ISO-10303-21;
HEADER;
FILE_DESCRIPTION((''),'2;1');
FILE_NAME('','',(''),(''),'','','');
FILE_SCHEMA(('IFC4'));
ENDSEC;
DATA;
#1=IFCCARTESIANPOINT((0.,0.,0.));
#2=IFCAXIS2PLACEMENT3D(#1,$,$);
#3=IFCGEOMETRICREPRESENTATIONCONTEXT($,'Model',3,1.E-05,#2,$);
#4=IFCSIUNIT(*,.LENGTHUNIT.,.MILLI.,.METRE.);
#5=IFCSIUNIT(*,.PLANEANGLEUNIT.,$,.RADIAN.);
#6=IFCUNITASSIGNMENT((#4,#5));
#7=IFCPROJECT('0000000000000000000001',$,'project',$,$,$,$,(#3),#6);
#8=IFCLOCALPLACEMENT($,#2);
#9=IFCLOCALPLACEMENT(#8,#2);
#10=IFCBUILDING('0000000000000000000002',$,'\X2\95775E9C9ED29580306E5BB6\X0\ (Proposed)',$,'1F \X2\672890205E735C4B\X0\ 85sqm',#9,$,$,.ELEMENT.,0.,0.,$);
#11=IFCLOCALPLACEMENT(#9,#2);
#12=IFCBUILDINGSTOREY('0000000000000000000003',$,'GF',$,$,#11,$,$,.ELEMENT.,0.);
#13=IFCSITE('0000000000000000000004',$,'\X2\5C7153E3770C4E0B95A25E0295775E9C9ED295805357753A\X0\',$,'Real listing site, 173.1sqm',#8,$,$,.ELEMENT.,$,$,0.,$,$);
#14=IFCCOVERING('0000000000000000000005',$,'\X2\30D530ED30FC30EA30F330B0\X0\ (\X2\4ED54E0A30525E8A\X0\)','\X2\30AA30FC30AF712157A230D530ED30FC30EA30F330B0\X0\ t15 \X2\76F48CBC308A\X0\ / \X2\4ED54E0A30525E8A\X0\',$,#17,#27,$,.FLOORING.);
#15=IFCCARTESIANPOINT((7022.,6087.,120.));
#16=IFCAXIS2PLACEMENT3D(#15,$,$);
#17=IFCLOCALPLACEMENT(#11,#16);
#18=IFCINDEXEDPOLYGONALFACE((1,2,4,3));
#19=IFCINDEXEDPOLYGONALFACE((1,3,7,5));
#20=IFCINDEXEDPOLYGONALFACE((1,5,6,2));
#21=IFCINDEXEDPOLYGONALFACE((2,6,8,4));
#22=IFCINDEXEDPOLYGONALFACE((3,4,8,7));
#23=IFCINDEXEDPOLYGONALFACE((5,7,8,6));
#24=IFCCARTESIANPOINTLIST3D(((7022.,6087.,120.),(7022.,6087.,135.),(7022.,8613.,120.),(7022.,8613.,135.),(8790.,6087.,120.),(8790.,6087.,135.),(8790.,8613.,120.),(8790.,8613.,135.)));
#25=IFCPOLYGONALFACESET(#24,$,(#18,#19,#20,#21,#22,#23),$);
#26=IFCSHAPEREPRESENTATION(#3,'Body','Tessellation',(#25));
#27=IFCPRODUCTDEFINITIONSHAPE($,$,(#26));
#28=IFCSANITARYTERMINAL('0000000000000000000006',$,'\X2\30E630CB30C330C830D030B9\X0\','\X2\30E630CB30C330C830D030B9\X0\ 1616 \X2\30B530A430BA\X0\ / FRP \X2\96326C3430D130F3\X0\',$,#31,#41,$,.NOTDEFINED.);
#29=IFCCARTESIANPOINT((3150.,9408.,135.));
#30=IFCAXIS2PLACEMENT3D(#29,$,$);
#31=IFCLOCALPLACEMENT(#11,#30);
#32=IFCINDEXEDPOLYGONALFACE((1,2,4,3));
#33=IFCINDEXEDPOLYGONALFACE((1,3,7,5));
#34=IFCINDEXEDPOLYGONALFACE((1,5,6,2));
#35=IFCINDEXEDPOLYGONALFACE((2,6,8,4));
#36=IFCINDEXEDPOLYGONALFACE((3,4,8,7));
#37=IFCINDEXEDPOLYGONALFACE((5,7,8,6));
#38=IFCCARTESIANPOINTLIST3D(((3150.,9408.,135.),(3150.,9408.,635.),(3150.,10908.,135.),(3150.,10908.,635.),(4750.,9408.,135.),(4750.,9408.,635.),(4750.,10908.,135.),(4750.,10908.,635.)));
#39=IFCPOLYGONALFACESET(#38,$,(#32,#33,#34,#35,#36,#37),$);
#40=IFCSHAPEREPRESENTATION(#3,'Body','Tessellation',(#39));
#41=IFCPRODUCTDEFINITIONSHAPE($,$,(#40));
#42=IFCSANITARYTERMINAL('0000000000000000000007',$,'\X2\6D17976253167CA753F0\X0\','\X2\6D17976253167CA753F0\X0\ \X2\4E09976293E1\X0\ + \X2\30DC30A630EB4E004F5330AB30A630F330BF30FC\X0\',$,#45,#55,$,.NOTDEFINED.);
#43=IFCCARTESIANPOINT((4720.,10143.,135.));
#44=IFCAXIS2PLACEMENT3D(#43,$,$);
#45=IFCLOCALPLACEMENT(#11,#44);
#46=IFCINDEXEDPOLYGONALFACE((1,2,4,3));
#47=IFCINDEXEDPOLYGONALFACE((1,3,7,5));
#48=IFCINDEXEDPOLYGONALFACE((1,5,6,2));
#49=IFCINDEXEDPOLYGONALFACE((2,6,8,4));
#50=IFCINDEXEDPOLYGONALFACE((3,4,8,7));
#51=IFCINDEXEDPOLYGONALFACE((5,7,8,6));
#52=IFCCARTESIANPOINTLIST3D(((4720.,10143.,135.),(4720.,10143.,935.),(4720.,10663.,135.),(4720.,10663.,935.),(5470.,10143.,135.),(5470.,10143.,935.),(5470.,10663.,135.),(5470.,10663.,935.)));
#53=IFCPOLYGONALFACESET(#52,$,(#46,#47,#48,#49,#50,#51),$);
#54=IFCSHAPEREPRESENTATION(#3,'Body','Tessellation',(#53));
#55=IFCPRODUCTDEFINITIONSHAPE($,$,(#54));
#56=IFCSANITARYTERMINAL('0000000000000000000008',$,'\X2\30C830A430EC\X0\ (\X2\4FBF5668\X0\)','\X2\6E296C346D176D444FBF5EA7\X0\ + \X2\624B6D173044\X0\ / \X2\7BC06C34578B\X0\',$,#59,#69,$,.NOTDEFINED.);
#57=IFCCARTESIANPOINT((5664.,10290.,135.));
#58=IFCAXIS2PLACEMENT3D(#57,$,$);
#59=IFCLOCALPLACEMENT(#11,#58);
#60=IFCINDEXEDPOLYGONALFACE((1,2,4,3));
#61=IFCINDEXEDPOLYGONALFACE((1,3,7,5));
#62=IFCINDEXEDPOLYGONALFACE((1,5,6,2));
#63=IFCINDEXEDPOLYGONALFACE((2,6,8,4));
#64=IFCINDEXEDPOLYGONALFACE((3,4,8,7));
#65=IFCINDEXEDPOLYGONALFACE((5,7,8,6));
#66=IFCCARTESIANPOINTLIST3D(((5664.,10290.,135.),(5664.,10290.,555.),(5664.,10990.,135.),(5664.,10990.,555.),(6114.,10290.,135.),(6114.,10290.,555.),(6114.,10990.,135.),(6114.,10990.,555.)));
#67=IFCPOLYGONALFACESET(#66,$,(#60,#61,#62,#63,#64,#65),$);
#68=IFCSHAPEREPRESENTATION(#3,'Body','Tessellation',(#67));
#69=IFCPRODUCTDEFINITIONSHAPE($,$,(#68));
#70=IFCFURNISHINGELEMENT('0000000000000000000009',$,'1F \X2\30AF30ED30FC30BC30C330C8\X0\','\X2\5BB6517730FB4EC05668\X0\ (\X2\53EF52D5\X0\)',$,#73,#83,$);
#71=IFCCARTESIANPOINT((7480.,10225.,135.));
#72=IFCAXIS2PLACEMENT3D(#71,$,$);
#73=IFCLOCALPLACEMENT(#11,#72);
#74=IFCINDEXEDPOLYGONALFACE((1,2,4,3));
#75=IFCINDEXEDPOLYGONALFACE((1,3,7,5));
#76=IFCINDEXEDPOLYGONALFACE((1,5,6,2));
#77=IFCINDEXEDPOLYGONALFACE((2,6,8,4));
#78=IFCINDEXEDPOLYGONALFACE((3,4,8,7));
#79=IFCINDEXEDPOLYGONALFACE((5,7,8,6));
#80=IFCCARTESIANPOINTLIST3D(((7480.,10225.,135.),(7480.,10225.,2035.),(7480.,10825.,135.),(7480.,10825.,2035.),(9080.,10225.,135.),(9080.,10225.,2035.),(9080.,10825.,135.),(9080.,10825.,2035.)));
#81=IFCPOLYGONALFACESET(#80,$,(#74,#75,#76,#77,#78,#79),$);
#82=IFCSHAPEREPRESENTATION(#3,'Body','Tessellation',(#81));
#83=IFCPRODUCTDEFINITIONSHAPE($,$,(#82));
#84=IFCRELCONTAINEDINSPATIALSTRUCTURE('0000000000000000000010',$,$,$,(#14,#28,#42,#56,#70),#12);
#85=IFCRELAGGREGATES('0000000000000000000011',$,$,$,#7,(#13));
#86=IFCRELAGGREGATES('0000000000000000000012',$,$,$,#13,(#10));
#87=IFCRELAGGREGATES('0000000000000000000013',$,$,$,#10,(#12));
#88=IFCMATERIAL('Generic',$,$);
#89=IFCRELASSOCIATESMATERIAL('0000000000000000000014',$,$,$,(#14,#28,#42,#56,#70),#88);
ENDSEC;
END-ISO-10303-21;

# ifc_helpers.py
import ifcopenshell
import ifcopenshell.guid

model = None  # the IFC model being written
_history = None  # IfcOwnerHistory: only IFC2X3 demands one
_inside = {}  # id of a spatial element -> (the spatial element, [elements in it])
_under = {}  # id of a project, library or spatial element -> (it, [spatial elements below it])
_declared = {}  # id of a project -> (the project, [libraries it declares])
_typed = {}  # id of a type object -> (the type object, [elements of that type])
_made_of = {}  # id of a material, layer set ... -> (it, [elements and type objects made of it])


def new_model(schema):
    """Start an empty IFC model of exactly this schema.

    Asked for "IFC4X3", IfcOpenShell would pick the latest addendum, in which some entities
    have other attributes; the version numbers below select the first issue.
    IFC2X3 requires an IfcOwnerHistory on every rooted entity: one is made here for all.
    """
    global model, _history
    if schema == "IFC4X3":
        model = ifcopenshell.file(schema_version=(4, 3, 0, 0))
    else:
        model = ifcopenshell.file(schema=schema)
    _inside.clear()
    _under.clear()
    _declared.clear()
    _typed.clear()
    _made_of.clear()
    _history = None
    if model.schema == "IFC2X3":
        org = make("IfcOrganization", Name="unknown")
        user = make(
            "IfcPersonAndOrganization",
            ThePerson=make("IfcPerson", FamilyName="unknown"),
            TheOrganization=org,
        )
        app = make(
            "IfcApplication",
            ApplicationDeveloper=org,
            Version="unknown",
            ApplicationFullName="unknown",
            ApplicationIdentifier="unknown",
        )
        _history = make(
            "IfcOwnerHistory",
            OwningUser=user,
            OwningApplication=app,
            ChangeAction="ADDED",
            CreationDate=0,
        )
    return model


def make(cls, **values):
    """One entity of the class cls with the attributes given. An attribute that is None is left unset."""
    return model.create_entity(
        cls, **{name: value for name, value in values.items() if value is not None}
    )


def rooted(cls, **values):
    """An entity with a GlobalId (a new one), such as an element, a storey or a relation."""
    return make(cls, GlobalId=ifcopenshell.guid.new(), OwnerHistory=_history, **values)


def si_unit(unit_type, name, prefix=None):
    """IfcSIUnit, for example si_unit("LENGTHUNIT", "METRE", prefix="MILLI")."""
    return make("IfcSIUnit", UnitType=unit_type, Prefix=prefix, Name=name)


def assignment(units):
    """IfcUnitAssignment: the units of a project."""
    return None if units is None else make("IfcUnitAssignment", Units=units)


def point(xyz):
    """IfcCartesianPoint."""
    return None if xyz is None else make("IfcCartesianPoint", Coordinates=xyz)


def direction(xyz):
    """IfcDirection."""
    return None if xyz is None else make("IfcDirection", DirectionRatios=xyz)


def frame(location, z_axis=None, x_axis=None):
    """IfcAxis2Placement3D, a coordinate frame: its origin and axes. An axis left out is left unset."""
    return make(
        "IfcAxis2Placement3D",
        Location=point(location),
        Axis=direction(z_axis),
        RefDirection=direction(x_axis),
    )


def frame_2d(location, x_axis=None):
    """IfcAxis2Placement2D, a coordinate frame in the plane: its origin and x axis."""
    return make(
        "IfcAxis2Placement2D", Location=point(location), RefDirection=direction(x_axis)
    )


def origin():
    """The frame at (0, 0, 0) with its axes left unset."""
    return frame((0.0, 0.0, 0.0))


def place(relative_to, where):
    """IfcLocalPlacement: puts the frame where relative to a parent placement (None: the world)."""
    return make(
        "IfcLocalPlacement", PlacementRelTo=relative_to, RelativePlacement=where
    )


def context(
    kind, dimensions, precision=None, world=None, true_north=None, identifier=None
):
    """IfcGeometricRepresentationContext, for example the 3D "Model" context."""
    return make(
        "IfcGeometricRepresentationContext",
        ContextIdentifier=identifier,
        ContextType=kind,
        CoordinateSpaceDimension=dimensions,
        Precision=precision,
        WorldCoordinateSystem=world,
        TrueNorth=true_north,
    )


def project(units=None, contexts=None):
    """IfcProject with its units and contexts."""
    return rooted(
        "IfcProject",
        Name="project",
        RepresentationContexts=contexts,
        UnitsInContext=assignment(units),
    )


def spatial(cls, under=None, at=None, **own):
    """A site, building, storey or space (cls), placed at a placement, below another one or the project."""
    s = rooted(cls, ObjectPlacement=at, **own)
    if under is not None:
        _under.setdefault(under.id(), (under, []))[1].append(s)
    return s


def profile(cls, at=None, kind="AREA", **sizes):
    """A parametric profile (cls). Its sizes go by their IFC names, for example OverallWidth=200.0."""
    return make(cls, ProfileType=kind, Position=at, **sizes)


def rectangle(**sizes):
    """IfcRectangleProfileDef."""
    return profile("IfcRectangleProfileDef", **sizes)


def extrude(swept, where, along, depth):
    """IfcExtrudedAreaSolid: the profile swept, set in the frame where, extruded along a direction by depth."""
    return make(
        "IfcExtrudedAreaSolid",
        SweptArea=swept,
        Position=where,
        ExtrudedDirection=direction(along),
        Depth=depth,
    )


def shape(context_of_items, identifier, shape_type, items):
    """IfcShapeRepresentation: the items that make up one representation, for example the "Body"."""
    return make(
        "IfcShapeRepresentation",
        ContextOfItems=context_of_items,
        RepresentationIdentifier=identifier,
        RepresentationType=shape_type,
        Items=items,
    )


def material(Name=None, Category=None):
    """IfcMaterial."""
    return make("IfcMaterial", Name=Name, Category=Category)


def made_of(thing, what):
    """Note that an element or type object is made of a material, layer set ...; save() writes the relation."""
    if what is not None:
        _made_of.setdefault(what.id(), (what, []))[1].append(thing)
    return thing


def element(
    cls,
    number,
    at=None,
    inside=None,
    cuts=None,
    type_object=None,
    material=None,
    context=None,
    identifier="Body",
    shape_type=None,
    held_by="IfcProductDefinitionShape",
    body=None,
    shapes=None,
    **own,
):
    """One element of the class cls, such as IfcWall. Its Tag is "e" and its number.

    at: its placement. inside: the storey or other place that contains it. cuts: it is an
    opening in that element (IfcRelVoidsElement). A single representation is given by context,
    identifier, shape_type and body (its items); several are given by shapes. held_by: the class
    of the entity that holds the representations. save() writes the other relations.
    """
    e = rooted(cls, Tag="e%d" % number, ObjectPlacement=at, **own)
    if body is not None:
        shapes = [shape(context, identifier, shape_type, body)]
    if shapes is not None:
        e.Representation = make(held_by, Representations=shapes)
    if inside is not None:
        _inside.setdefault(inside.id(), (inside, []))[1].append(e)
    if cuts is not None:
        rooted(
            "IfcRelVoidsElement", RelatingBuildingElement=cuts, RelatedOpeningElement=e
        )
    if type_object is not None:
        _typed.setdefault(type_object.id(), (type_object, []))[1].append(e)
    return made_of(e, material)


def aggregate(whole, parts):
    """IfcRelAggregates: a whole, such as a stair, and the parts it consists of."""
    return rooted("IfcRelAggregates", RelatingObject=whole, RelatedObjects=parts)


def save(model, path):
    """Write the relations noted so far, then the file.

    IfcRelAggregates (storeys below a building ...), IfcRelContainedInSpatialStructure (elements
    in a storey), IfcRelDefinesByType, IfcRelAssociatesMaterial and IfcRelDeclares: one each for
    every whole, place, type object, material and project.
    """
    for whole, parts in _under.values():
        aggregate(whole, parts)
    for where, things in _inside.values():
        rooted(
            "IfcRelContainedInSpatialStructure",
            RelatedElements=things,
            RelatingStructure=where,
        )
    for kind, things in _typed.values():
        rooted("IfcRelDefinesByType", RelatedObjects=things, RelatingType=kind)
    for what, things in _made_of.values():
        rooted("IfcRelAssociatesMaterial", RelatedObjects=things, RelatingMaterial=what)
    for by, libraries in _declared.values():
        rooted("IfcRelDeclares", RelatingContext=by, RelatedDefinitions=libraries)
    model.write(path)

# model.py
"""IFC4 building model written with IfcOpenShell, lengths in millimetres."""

from ifc_helpers import new_model, si_unit, frame, frame_2d, origin, place, context, project, spatial, rectangle, extrude, material, element, save


model = new_model("IFC4")

# Units and contexts
model_context = context("Model", 3, precision=1e-05, world=origin())
ifc_project = project(units=[si_unit("LENGTHUNIT", "METRE", prefix="MILLI"), si_unit("PLANEANGLEUNIT", "RADIAN")], contexts=[model_context])

# Site, building, storey
site_placement = place(None, origin())
site = spatial("IfcSite", under=ifc_project, at=site_placement, Name="山口県下関市長府黒門南町", ObjectType="Real listing site, 173.1sqm", CompositionType="ELEMENT", RefElevation=0.0)
building_placement = place(site_placement, origin())
building = spatial("IfcBuilding", under=site, at=building_placement, Name="長府黒門の家 (Proposed)", ObjectType="1F 木造平屋 85sqm", CompositionType="ELEMENT", ElevationOfRefHeight=0.0, ElevationOfTerrain=0.0)
storey_placement = place(building_placement, origin())
storey = spatial("IfcBuildingStorey", under=building, at=storey_placement, Name="GF", CompositionType="ELEMENT", Elevation=0.0)

# Covering
ifc_material_1 = material(Name="Generic")
covering_1_placement = place(storey_placement, frame((7022.0, 6087.0, 120.0)))
element("IfcCovering", 1, at=covering_1_placement, inside=storey, material=ifc_material_1, Name="フローリング (仕上げ床)", Description="オーク無垢フローリング t15 直貼り / 仕上げ床", PredefinedType="FLOORING", context=model_context, shape_type="SweptSolid", body=[
    extrude(rectangle(XDim=1768.0, YDim=2526.0, at=frame_2d((884.0, 1263.0))), frame((7022.0, 6087.0, 120.0)), (0.0, 0.0, 1.0), 15.0),
])

# Sanitary terminals
sanitary_terminal_1_placement = place(storey_placement, frame((3150.0, 9408.0, 135.0)))
element("IfcSanitaryTerminal", 2, at=sanitary_terminal_1_placement, inside=storey, material=ifc_material_1, Name="ユニットバス", Description="ユニットバス 1616 サイズ / FRP 防水パン", PredefinedType="NOTDEFINED", context=model_context, shape_type="SweptSolid", body=[
    extrude(rectangle(XDim=1600.0, YDim=1500.0, at=frame_2d((800.0, 750.0))), frame((3150.0, 9408.0, 135.0)), (0.0, 0.0, 1.0), 500.0),
])
sanitary_terminal_2_placement = place(storey_placement, frame((4720.0, 10143.0, 135.0)))
element("IfcSanitaryTerminal", 3, at=sanitary_terminal_2_placement, inside=storey, material=ifc_material_1, Name="洗面化粧台", Description="洗面化粧台 三面鏡 + ボウル一体カウンター", PredefinedType="NOTDEFINED", context=model_context, shape_type="SweptSolid", body=[
    extrude(rectangle(XDim=750.0, YDim=520.0, at=frame_2d((375.0, 260.0))), frame((4720.0, 10143.0, 135.0)), (0.0, 0.0, 1.0), 800.0),
])
sanitary_terminal_3_placement = place(storey_placement, frame((5664.0, 10290.0, 135.0)))
element("IfcSanitaryTerminal", 4, at=sanitary_terminal_3_placement, inside=storey, material=ifc_material_1, Name="トイレ (便器)", Description="温水洗浄便座 + 手洗い / 節水型", PredefinedType="NOTDEFINED", context=model_context, shape_type="SweptSolid", body=[
    extrude(rectangle(XDim=450.0, YDim=700.0, at=frame_2d((225.0, 350.0))), frame((5664.0, 10290.0, 135.0)), (0.0, 0.0, 1.0), 420.0),
])

# Furnishing element
furnishing_placement = place(storey_placement, frame((7480.0, 10225.0, 135.0)))
element("IfcFurnishingElement", 5, at=furnishing_placement, inside=storey, material=ifc_material_1, Name="1F クローゼット", Description="家具・什器 (可動)", context=model_context, shape_type="SweptSolid", body=[
    extrude(rectangle(XDim=1600.0, YDim=600.0, at=frame_2d((800.0, 300.0))), frame((7480.0, 10225.0, 135.0)), (0.0, 0.0, 1.0), 1900.0),
])

save(model, "model.ifc")
